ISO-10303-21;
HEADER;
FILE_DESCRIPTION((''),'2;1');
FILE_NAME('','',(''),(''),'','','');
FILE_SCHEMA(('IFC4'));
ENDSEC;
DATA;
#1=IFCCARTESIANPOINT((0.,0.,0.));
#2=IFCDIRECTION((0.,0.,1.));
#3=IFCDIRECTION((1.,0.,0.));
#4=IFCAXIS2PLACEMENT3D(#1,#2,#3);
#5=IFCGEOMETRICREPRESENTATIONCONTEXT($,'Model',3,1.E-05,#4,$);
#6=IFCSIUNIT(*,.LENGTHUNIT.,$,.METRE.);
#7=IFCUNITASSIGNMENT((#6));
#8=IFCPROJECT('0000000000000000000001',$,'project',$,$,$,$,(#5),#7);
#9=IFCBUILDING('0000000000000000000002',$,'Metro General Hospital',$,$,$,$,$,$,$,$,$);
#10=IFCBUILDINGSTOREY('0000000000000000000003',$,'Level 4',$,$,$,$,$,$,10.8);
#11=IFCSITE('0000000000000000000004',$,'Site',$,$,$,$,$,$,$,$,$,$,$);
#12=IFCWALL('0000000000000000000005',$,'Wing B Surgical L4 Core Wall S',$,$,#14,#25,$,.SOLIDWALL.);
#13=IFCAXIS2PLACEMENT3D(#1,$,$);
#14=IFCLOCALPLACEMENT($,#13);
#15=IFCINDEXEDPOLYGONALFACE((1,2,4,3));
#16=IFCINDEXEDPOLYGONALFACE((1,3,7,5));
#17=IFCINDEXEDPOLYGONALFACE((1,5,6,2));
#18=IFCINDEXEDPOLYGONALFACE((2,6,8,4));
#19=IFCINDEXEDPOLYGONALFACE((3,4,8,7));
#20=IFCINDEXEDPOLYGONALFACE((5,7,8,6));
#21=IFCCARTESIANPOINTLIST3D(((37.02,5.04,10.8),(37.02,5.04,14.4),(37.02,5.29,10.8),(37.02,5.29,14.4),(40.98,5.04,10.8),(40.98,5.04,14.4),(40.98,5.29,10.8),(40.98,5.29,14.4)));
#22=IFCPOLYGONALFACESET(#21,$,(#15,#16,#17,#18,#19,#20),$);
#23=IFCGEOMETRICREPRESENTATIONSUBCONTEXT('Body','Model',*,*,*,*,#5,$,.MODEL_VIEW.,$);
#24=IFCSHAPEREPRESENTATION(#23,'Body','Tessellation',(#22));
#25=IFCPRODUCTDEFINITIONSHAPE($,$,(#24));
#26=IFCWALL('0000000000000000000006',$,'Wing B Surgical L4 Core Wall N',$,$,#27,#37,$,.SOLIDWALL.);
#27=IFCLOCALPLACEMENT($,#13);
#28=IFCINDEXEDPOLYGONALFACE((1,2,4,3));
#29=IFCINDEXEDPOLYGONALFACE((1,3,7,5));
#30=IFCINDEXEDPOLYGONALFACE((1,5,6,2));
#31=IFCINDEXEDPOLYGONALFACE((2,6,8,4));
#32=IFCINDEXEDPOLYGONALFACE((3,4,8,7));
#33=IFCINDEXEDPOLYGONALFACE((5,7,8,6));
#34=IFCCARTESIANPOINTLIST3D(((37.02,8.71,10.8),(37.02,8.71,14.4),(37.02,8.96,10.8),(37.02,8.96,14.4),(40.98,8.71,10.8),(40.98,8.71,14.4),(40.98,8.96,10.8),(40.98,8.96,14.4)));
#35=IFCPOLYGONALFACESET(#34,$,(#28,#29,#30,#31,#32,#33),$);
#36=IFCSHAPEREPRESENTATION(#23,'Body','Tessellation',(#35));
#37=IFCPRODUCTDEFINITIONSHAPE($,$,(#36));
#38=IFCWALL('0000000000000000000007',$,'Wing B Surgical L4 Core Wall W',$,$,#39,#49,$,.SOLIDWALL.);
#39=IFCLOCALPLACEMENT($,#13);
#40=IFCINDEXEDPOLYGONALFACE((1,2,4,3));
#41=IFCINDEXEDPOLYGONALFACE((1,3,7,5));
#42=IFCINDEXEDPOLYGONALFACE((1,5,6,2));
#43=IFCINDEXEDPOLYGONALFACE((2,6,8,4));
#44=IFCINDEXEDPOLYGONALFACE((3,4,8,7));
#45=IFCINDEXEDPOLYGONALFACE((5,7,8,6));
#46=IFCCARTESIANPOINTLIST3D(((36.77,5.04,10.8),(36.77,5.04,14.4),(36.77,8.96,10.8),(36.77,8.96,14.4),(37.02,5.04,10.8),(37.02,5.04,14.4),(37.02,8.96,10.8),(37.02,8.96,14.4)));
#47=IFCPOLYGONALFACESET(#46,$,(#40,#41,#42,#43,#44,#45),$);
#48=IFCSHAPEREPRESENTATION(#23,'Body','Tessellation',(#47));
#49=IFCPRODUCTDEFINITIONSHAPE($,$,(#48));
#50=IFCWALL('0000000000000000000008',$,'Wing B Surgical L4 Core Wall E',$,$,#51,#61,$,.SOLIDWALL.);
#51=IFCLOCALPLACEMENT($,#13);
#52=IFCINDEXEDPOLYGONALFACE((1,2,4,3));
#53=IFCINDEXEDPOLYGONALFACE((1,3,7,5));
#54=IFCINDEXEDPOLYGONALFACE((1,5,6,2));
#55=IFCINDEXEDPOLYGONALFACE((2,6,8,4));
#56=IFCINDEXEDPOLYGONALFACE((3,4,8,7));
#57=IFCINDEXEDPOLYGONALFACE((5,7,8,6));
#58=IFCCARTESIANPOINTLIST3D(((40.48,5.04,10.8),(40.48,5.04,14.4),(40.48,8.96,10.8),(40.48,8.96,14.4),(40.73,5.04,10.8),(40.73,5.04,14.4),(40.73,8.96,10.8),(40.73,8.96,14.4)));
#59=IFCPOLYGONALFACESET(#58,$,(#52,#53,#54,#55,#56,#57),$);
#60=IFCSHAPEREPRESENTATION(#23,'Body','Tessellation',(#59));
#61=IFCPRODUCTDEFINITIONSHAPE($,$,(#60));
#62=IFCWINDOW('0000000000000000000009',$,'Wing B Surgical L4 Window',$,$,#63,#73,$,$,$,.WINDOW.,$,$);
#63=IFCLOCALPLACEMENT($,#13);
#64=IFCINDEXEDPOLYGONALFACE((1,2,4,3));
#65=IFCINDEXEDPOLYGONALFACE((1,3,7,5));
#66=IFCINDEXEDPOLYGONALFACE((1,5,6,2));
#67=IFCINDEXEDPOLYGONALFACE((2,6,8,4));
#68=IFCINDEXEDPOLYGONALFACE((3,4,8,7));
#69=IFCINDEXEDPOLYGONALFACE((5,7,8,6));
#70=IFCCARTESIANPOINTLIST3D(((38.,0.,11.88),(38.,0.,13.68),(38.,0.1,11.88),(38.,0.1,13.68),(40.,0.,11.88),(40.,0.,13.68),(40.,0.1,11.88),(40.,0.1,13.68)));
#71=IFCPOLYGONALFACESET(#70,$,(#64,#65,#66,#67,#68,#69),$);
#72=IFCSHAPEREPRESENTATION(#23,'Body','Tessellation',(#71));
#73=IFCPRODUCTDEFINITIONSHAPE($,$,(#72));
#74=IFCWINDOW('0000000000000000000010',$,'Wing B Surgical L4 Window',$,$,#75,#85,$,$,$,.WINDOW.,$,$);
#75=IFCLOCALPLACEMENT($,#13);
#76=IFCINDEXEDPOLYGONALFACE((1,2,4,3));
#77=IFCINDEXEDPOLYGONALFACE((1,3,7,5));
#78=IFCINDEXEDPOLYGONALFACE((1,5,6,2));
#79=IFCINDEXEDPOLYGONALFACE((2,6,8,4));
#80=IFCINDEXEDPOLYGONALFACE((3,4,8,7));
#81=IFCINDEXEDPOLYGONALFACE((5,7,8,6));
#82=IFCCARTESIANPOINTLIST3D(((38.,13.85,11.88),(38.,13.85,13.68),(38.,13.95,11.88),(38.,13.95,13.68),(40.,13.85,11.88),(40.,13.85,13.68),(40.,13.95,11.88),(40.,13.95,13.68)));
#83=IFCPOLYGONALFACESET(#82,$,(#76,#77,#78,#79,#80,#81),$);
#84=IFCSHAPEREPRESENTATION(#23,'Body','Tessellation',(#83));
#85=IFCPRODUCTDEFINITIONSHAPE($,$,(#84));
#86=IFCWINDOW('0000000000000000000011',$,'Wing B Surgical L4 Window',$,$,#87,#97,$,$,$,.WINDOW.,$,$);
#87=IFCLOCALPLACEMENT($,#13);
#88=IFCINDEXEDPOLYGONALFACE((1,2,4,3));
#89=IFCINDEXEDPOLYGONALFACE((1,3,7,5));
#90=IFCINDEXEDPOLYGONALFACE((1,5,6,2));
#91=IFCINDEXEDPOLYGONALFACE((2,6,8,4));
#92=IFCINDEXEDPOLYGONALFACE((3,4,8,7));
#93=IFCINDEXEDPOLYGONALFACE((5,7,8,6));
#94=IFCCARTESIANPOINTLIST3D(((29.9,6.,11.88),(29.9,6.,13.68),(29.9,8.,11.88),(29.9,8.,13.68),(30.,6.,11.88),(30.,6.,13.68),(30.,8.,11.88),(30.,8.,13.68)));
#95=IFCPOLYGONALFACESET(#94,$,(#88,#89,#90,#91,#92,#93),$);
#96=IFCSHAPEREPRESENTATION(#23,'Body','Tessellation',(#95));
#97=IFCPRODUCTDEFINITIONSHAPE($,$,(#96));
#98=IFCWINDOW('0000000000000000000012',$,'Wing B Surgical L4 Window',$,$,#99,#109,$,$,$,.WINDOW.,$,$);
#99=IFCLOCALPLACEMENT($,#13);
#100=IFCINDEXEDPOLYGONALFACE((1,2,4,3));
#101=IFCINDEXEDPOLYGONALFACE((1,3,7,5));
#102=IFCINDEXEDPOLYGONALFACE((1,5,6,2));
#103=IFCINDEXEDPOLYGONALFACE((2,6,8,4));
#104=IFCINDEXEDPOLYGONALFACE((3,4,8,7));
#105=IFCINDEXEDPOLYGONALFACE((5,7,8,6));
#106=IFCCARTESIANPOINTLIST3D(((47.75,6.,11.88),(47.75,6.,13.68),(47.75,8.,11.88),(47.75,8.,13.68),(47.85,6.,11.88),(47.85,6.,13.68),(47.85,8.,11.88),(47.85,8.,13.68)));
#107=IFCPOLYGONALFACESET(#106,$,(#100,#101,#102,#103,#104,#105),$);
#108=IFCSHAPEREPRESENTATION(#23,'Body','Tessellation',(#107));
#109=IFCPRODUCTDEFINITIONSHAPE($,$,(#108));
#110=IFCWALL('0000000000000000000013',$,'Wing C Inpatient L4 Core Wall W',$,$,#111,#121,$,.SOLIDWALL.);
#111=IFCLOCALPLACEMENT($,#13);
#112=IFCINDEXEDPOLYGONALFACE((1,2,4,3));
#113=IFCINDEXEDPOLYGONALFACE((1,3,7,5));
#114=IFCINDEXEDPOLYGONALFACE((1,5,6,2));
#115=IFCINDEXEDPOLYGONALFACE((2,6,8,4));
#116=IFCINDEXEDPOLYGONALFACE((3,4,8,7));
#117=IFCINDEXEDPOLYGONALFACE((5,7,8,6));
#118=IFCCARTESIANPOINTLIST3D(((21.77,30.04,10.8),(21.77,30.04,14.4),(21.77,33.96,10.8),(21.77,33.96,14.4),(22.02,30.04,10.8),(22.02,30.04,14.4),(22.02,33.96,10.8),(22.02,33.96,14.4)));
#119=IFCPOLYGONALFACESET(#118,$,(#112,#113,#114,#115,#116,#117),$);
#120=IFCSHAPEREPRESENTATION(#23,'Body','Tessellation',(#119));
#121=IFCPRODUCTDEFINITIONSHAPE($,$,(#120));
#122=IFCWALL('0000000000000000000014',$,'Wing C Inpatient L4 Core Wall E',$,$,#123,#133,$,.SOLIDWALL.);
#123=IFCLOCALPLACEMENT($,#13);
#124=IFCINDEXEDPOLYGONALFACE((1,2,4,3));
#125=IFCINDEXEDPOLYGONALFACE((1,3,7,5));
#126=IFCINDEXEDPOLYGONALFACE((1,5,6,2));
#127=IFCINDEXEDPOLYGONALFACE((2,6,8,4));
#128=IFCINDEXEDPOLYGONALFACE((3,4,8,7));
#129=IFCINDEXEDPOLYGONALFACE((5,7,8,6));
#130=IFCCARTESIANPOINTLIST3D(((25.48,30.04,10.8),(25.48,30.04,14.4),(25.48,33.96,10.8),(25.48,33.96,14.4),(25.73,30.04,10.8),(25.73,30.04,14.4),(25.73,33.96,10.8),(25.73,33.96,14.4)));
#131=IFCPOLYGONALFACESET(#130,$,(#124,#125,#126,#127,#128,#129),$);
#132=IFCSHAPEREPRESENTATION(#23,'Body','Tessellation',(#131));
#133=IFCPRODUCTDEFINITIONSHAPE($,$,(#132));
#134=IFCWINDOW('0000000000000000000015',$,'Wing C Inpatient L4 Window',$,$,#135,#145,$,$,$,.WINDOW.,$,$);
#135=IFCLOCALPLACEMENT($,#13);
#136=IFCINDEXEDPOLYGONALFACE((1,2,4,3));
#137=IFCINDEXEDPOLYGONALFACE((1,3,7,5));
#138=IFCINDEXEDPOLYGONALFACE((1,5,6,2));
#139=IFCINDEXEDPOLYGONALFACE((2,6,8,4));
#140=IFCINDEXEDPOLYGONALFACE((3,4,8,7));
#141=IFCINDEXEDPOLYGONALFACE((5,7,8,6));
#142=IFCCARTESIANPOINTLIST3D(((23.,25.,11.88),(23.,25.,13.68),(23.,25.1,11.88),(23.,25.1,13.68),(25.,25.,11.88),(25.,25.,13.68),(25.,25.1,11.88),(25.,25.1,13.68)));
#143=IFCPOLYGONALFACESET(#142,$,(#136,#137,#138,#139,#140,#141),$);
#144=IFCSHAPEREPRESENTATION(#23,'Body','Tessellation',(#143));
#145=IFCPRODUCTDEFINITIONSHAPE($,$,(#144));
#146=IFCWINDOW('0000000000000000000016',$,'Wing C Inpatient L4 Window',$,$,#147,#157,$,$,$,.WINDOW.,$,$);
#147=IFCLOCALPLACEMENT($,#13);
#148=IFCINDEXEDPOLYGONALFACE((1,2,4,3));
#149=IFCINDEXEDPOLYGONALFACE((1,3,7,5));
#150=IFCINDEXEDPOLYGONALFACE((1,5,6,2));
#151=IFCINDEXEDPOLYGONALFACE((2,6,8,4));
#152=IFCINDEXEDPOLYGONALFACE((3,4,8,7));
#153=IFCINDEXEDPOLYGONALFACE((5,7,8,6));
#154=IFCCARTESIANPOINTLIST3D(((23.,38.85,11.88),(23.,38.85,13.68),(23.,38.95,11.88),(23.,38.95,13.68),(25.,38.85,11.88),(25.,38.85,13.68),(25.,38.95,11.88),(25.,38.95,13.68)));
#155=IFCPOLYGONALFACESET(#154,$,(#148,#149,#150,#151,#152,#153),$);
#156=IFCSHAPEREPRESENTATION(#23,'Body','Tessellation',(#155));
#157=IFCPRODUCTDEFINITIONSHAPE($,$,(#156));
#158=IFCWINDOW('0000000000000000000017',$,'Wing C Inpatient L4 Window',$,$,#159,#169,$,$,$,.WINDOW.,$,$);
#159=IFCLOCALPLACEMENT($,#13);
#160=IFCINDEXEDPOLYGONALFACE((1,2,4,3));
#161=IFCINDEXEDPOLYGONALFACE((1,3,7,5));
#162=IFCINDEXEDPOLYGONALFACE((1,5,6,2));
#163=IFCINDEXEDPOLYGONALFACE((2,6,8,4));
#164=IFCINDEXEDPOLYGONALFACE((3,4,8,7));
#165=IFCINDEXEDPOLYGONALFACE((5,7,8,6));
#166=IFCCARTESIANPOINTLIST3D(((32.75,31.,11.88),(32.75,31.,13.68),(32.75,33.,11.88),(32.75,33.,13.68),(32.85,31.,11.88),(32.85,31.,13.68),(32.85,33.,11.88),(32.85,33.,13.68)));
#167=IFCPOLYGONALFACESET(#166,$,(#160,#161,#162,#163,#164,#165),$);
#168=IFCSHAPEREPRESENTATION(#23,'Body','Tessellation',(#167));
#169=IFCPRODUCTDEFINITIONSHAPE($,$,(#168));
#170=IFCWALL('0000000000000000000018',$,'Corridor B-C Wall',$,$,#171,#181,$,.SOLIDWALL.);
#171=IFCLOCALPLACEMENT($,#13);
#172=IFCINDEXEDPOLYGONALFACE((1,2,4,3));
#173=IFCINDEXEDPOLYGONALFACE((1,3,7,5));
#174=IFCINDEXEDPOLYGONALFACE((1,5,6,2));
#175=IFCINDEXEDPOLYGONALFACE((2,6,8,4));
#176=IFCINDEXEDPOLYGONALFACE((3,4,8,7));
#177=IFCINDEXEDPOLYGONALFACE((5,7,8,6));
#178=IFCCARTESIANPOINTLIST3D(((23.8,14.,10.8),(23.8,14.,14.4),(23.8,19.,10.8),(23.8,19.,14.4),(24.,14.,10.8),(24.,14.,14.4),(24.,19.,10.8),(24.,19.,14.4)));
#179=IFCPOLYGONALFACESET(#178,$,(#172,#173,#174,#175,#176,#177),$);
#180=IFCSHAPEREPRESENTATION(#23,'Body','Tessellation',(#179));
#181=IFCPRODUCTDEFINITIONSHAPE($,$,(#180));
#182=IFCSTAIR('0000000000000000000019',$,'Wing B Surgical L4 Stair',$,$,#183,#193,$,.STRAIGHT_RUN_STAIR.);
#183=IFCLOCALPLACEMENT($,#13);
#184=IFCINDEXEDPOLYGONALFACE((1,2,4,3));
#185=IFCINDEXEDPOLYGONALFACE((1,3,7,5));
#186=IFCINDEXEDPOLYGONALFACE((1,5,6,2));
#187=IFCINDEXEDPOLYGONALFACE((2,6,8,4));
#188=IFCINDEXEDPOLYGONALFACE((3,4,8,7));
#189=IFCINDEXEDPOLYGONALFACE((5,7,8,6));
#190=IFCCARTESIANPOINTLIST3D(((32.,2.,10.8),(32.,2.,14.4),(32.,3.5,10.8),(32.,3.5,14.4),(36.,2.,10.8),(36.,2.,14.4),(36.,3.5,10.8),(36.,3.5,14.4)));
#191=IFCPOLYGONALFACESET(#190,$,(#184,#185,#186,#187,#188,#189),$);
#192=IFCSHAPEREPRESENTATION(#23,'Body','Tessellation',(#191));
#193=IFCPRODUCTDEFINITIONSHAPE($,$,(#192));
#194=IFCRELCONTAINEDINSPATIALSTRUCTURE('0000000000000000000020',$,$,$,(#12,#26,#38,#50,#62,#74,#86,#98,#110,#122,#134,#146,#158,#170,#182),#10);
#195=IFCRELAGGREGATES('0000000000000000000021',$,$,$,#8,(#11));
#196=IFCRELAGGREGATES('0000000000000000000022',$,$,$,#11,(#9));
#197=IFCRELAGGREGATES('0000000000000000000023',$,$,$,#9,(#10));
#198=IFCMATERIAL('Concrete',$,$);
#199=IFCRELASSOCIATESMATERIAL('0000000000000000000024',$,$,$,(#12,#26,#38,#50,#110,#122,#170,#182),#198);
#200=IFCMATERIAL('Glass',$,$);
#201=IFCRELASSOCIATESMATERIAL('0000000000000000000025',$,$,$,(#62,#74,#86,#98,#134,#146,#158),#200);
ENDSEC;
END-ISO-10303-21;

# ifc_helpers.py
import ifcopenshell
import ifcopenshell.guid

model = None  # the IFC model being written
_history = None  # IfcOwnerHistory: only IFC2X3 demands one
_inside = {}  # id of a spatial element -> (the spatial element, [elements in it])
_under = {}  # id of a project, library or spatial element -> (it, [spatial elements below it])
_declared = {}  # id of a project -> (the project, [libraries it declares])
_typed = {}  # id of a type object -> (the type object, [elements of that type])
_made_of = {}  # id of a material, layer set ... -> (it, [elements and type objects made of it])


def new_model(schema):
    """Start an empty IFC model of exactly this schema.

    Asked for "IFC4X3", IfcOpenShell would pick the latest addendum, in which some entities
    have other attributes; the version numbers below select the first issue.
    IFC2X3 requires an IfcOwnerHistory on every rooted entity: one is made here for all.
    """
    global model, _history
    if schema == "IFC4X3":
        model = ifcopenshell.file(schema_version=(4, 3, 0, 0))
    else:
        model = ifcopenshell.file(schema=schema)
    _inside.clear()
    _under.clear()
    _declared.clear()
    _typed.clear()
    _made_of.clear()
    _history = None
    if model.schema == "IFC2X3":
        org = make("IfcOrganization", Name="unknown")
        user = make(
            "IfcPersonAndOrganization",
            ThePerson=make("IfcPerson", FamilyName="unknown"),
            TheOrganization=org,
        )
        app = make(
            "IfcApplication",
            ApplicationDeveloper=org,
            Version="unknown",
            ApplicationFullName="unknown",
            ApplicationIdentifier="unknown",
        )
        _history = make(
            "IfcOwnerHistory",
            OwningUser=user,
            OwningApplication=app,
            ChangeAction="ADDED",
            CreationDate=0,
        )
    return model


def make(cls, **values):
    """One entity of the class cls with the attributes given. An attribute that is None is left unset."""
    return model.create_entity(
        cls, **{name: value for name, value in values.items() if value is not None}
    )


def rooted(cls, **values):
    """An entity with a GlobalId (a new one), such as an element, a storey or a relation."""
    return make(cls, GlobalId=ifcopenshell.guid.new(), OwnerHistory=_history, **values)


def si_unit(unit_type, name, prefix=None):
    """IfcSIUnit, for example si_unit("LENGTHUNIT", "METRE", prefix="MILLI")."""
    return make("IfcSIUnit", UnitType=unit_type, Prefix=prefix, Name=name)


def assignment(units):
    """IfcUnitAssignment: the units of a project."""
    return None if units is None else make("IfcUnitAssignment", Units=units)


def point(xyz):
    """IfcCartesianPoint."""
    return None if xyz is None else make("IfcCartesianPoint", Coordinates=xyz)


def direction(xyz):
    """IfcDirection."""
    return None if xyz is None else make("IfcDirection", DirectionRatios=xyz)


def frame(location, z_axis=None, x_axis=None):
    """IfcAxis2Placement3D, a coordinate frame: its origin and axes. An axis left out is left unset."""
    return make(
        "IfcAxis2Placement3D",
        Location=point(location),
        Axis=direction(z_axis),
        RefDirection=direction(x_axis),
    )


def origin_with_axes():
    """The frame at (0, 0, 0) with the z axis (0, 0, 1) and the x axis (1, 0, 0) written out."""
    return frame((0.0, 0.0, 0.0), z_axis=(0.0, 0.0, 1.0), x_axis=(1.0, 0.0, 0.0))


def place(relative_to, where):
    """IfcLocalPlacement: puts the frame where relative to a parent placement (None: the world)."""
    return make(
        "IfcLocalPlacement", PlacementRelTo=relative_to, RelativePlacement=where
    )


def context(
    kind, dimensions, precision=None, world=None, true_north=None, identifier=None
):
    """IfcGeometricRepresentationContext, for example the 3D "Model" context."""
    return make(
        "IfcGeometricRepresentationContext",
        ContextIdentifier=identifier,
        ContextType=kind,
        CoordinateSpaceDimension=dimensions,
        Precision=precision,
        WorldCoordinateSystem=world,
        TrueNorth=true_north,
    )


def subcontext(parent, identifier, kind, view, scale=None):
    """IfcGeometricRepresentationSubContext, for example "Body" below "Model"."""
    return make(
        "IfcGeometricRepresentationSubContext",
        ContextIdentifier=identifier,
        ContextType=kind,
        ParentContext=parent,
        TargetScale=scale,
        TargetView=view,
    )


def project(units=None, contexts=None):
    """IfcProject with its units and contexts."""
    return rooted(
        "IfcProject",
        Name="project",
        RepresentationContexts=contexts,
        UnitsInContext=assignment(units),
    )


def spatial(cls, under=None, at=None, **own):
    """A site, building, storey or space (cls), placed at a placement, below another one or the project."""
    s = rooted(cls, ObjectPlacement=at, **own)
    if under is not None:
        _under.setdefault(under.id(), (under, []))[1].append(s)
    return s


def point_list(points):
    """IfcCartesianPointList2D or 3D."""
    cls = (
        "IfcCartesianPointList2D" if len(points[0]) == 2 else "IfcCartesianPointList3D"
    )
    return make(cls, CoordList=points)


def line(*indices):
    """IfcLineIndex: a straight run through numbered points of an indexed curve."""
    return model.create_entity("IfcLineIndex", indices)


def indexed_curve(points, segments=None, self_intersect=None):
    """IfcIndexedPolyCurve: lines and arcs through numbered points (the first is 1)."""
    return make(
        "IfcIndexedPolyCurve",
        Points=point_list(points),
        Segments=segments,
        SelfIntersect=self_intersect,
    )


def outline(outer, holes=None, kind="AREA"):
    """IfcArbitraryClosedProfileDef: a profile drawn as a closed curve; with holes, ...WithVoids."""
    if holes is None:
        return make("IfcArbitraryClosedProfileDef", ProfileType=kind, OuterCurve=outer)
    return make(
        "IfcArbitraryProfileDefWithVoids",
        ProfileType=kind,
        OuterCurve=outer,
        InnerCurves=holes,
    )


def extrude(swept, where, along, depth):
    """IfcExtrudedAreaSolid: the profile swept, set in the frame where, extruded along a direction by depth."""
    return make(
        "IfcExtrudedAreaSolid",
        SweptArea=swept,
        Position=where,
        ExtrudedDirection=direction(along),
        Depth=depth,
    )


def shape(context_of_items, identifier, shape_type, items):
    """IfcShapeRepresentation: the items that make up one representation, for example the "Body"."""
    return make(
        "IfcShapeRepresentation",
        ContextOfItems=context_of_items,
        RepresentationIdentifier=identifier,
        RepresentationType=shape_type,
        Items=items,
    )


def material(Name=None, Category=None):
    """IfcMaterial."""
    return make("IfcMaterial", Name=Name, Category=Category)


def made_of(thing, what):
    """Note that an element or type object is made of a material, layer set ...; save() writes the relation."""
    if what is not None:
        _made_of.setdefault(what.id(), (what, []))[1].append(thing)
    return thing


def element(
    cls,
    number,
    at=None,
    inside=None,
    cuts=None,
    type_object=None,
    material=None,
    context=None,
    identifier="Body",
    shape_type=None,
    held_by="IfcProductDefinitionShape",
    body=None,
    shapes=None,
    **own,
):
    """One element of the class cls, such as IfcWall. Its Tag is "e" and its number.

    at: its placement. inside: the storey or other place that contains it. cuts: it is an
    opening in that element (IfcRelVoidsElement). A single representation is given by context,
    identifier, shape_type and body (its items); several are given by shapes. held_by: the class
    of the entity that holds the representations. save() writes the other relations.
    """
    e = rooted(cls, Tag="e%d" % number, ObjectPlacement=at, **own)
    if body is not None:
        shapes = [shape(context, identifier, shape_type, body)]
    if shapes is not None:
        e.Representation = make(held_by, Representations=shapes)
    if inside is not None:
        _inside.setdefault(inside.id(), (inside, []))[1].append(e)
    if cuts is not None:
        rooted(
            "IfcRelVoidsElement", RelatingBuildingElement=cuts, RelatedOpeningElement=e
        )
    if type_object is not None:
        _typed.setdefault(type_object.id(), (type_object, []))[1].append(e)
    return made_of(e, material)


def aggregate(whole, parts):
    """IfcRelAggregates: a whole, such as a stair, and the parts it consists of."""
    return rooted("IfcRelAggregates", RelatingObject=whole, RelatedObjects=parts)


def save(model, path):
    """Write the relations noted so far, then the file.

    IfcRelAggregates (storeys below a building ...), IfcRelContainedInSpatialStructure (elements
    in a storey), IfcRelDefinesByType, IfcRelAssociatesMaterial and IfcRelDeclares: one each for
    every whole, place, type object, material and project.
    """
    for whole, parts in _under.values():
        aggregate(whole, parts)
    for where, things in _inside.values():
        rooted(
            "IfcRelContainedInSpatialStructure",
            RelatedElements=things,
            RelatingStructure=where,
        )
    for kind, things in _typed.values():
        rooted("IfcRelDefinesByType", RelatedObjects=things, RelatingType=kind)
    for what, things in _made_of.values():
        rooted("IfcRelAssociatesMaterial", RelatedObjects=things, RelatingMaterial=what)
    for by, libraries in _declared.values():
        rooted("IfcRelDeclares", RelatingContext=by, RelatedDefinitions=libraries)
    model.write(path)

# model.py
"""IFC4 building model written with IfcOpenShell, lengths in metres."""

from ifc_helpers import new_model, si_unit, frame, origin_with_axes, place, context, subcontext, project, spatial, line, indexed_curve, outline, extrude, material, element, save


model = new_model("IFC4")

# Units and contexts
model_context = context("Model", 3, precision=1e-05, world=origin_with_axes())
body_context = subcontext(model_context, "Body", "Model", "MODEL_VIEW")
ifc_project = project(units=[si_unit("LENGTHUNIT", "METRE")], contexts=[model_context])

# Site, building, storey
site = spatial("IfcSite", under=ifc_project, Name="Site")
building = spatial("IfcBuilding", under=site, Name="Metro General Hospital")
storey = spatial("IfcBuildingStorey", under=building, Name="Level 4", Elevation=10.8)

# Shared definitions
ifc_material_1 = material(Name="Concrete")

# Walls
for number, where, z_axis, x_axis, name in (
    (1, (37.02, 5.04, 10.8), (0.0, 0.0, 1.0), (1.0, 0.0, 0.0), "Wing B Surgical L4 Core Wall S"),
    (2, (37.02, 8.71, 10.8), (0.0, 0.0, 1.0), (1.0, 0.0, 0.0), "Wing B Surgical L4 Core Wall N"),
):
    element("IfcWall", number, at=place(None, frame(where, z_axis=z_axis, x_axis=x_axis)), inside=storey, material=ifc_material_1, Name=name, PredefinedType="SOLIDWALL", context=body_context, shape_type="SweptSolid", body=[
        extrude(outline(indexed_curve([(0.0, 0.0), (3.96, 0.0), (3.96, 0.25), (0.0, 0.25)], segments=[line(1, 2, 3, 4, 1)])), origin_with_axes(), (0.0, 0.0, 1.0), 3.6),
    ])
for number, where, z_axis, x_axis, name in (
    (3, (37.02, 5.04, 10.8), (0.0, 0.0, 1.0), (0.0, 1.0, 0.0), "Wing B Surgical L4 Core Wall W"),
    (4, (40.73, 5.04, 10.8), (0.0, 0.0, 1.0), (0.0, 1.0, 0.0), "Wing B Surgical L4 Core Wall E"),
):
    element("IfcWall", number, at=place(None, frame(where, z_axis=z_axis, x_axis=x_axis)), inside=storey, material=ifc_material_1, Name=name, PredefinedType="SOLIDWALL", context=body_context, shape_type="SweptSolid", body=[
        extrude(outline(indexed_curve([(0.0, 0.0), (3.92, 0.0), (3.92, 0.25), (0.0, 0.25)], segments=[line(1, 2, 3, 4, 1)])), origin_with_axes(), (0.0, 0.0, 1.0), 3.6),
    ])

# Windows
ifc_material_2 = material(Name="Glass")
for number, where, z_axis, x_axis, name in (
    (5, (38.0, 0.0, 11.88), (0.0, 0.0, 1.0), (1.0, 0.0, 0.0), "Wing B Surgical L4 Window"),
    (6, (38.0, 13.85, 11.88), (0.0, 0.0, 1.0), (1.0, 0.0, 0.0), "Wing B Surgical L4 Window"),
    (7, (30.0, 6.0, 11.88), (0.0, 0.0, 1.0), (0.0, 1.0, 0.0), "Wing B Surgical L4 Window"),
    (8, (47.85, 6.0, 11.88), (0.0, 0.0, 1.0), (0.0, 1.0, 0.0), "Wing B Surgical L4 Window"),
):
    element("IfcWindow", number, at=place(None, frame(where, z_axis=z_axis, x_axis=x_axis)), inside=storey, material=ifc_material_2, Name=name, PredefinedType="WINDOW", context=body_context, shape_type="SweptSolid", body=[
        extrude(outline(indexed_curve([(0.0, 0.0), (2.0, 0.0), (2.0, 0.1), (0.0, 0.1)], segments=[line(1, 2, 3, 4, 1)])), origin_with_axes(), (0.0, 0.0, 1.0), 1.8),
    ])

# Walls
for number, where, z_axis, x_axis, name in (
    (9, (22.02, 30.04, 10.8), (0.0, 0.0, 1.0), (0.0, 1.0, 0.0), "Wing C Inpatient L4 Core Wall W"),
    (10, (25.73, 30.04, 10.8), (0.0, 0.0, 1.0), (0.0, 1.0, 0.0), "Wing C Inpatient L4 Core Wall E"),
):
    element("IfcWall", number, at=place(None, frame(where, z_axis=z_axis, x_axis=x_axis)), inside=storey, material=ifc_material_1, Name=name, PredefinedType="SOLIDWALL", context=body_context, shape_type="SweptSolid", body=[
        extrude(outline(indexed_curve([(0.0, 0.0), (3.92, 0.0), (3.92, 0.25), (0.0, 0.25)], segments=[line(1, 2, 3, 4, 1)])), origin_with_axes(), (0.0, 0.0, 1.0), 3.6),
    ])

# Windows
for number, where, z_axis, x_axis, name in (
    (11, (23.0, 25.0, 11.88), (0.0, 0.0, 1.0), (1.0, 0.0, 0.0), "Wing C Inpatient L4 Window"),
    (12, (23.0, 38.85, 11.88), (0.0, 0.0, 1.0), (1.0, 0.0, 0.0), "Wing C Inpatient L4 Window"),
    (13, (32.85, 31.0, 11.88), (0.0, 0.0, 1.0), (0.0, 1.0, 0.0), "Wing C Inpatient L4 Window"),
):
    element("IfcWindow", number, at=place(None, frame(where, z_axis=z_axis, x_axis=x_axis)), inside=storey, material=ifc_material_2, Name=name, PredefinedType="WINDOW", context=body_context, shape_type="SweptSolid", body=[
        extrude(outline(indexed_curve([(0.0, 0.0), (2.0, 0.0), (2.0, 0.1), (0.0, 0.1)], segments=[line(1, 2, 3, 4, 1)])), origin_with_axes(), (0.0, 0.0, 1.0), 1.8),
    ])

# Wall
wall_placement = place(None, frame((24.0, 14.0, 10.8), z_axis=(0.0, 0.0, 1.0), x_axis=(0.0, 1.0, 0.0)))
element("IfcWall", 14, at=wall_placement, inside=storey, material=ifc_material_1, Name="Corridor B-C Wall", PredefinedType="SOLIDWALL", context=body_context, shape_type="SweptSolid", body=[
    extrude(outline(indexed_curve([(0.0, 0.0), (5.0, 0.0), (5.0, 0.2), (0.0, 0.2)], segments=[line(1, 2, 3, 4, 1)])), origin_with_axes(), (0.0, 0.0, 1.0), 3.6),
])

# Stair
stair_placement = place(None, frame((32.0, 2.0, 10.8), z_axis=(0.0, 0.0, 1.0), x_axis=(1.0, 0.0, 0.0)))
element("IfcStair", 15, at=stair_placement, inside=storey, material=ifc_material_1, Name="Wing B Surgical L4 Stair", PredefinedType="STRAIGHT_RUN_STAIR", context=body_context, shape_type="SweptSolid", body=[
    extrude(outline(indexed_curve([(0.0, 0.0), (4.0, 0.0), (4.0, 1.5), (0.0, 1.5)], segments=[line(1, 2, 3, 4, 1)])), origin_with_axes(), (0.0, 0.0, 1.0), 3.6),
])

save(model, "model.ifc")
